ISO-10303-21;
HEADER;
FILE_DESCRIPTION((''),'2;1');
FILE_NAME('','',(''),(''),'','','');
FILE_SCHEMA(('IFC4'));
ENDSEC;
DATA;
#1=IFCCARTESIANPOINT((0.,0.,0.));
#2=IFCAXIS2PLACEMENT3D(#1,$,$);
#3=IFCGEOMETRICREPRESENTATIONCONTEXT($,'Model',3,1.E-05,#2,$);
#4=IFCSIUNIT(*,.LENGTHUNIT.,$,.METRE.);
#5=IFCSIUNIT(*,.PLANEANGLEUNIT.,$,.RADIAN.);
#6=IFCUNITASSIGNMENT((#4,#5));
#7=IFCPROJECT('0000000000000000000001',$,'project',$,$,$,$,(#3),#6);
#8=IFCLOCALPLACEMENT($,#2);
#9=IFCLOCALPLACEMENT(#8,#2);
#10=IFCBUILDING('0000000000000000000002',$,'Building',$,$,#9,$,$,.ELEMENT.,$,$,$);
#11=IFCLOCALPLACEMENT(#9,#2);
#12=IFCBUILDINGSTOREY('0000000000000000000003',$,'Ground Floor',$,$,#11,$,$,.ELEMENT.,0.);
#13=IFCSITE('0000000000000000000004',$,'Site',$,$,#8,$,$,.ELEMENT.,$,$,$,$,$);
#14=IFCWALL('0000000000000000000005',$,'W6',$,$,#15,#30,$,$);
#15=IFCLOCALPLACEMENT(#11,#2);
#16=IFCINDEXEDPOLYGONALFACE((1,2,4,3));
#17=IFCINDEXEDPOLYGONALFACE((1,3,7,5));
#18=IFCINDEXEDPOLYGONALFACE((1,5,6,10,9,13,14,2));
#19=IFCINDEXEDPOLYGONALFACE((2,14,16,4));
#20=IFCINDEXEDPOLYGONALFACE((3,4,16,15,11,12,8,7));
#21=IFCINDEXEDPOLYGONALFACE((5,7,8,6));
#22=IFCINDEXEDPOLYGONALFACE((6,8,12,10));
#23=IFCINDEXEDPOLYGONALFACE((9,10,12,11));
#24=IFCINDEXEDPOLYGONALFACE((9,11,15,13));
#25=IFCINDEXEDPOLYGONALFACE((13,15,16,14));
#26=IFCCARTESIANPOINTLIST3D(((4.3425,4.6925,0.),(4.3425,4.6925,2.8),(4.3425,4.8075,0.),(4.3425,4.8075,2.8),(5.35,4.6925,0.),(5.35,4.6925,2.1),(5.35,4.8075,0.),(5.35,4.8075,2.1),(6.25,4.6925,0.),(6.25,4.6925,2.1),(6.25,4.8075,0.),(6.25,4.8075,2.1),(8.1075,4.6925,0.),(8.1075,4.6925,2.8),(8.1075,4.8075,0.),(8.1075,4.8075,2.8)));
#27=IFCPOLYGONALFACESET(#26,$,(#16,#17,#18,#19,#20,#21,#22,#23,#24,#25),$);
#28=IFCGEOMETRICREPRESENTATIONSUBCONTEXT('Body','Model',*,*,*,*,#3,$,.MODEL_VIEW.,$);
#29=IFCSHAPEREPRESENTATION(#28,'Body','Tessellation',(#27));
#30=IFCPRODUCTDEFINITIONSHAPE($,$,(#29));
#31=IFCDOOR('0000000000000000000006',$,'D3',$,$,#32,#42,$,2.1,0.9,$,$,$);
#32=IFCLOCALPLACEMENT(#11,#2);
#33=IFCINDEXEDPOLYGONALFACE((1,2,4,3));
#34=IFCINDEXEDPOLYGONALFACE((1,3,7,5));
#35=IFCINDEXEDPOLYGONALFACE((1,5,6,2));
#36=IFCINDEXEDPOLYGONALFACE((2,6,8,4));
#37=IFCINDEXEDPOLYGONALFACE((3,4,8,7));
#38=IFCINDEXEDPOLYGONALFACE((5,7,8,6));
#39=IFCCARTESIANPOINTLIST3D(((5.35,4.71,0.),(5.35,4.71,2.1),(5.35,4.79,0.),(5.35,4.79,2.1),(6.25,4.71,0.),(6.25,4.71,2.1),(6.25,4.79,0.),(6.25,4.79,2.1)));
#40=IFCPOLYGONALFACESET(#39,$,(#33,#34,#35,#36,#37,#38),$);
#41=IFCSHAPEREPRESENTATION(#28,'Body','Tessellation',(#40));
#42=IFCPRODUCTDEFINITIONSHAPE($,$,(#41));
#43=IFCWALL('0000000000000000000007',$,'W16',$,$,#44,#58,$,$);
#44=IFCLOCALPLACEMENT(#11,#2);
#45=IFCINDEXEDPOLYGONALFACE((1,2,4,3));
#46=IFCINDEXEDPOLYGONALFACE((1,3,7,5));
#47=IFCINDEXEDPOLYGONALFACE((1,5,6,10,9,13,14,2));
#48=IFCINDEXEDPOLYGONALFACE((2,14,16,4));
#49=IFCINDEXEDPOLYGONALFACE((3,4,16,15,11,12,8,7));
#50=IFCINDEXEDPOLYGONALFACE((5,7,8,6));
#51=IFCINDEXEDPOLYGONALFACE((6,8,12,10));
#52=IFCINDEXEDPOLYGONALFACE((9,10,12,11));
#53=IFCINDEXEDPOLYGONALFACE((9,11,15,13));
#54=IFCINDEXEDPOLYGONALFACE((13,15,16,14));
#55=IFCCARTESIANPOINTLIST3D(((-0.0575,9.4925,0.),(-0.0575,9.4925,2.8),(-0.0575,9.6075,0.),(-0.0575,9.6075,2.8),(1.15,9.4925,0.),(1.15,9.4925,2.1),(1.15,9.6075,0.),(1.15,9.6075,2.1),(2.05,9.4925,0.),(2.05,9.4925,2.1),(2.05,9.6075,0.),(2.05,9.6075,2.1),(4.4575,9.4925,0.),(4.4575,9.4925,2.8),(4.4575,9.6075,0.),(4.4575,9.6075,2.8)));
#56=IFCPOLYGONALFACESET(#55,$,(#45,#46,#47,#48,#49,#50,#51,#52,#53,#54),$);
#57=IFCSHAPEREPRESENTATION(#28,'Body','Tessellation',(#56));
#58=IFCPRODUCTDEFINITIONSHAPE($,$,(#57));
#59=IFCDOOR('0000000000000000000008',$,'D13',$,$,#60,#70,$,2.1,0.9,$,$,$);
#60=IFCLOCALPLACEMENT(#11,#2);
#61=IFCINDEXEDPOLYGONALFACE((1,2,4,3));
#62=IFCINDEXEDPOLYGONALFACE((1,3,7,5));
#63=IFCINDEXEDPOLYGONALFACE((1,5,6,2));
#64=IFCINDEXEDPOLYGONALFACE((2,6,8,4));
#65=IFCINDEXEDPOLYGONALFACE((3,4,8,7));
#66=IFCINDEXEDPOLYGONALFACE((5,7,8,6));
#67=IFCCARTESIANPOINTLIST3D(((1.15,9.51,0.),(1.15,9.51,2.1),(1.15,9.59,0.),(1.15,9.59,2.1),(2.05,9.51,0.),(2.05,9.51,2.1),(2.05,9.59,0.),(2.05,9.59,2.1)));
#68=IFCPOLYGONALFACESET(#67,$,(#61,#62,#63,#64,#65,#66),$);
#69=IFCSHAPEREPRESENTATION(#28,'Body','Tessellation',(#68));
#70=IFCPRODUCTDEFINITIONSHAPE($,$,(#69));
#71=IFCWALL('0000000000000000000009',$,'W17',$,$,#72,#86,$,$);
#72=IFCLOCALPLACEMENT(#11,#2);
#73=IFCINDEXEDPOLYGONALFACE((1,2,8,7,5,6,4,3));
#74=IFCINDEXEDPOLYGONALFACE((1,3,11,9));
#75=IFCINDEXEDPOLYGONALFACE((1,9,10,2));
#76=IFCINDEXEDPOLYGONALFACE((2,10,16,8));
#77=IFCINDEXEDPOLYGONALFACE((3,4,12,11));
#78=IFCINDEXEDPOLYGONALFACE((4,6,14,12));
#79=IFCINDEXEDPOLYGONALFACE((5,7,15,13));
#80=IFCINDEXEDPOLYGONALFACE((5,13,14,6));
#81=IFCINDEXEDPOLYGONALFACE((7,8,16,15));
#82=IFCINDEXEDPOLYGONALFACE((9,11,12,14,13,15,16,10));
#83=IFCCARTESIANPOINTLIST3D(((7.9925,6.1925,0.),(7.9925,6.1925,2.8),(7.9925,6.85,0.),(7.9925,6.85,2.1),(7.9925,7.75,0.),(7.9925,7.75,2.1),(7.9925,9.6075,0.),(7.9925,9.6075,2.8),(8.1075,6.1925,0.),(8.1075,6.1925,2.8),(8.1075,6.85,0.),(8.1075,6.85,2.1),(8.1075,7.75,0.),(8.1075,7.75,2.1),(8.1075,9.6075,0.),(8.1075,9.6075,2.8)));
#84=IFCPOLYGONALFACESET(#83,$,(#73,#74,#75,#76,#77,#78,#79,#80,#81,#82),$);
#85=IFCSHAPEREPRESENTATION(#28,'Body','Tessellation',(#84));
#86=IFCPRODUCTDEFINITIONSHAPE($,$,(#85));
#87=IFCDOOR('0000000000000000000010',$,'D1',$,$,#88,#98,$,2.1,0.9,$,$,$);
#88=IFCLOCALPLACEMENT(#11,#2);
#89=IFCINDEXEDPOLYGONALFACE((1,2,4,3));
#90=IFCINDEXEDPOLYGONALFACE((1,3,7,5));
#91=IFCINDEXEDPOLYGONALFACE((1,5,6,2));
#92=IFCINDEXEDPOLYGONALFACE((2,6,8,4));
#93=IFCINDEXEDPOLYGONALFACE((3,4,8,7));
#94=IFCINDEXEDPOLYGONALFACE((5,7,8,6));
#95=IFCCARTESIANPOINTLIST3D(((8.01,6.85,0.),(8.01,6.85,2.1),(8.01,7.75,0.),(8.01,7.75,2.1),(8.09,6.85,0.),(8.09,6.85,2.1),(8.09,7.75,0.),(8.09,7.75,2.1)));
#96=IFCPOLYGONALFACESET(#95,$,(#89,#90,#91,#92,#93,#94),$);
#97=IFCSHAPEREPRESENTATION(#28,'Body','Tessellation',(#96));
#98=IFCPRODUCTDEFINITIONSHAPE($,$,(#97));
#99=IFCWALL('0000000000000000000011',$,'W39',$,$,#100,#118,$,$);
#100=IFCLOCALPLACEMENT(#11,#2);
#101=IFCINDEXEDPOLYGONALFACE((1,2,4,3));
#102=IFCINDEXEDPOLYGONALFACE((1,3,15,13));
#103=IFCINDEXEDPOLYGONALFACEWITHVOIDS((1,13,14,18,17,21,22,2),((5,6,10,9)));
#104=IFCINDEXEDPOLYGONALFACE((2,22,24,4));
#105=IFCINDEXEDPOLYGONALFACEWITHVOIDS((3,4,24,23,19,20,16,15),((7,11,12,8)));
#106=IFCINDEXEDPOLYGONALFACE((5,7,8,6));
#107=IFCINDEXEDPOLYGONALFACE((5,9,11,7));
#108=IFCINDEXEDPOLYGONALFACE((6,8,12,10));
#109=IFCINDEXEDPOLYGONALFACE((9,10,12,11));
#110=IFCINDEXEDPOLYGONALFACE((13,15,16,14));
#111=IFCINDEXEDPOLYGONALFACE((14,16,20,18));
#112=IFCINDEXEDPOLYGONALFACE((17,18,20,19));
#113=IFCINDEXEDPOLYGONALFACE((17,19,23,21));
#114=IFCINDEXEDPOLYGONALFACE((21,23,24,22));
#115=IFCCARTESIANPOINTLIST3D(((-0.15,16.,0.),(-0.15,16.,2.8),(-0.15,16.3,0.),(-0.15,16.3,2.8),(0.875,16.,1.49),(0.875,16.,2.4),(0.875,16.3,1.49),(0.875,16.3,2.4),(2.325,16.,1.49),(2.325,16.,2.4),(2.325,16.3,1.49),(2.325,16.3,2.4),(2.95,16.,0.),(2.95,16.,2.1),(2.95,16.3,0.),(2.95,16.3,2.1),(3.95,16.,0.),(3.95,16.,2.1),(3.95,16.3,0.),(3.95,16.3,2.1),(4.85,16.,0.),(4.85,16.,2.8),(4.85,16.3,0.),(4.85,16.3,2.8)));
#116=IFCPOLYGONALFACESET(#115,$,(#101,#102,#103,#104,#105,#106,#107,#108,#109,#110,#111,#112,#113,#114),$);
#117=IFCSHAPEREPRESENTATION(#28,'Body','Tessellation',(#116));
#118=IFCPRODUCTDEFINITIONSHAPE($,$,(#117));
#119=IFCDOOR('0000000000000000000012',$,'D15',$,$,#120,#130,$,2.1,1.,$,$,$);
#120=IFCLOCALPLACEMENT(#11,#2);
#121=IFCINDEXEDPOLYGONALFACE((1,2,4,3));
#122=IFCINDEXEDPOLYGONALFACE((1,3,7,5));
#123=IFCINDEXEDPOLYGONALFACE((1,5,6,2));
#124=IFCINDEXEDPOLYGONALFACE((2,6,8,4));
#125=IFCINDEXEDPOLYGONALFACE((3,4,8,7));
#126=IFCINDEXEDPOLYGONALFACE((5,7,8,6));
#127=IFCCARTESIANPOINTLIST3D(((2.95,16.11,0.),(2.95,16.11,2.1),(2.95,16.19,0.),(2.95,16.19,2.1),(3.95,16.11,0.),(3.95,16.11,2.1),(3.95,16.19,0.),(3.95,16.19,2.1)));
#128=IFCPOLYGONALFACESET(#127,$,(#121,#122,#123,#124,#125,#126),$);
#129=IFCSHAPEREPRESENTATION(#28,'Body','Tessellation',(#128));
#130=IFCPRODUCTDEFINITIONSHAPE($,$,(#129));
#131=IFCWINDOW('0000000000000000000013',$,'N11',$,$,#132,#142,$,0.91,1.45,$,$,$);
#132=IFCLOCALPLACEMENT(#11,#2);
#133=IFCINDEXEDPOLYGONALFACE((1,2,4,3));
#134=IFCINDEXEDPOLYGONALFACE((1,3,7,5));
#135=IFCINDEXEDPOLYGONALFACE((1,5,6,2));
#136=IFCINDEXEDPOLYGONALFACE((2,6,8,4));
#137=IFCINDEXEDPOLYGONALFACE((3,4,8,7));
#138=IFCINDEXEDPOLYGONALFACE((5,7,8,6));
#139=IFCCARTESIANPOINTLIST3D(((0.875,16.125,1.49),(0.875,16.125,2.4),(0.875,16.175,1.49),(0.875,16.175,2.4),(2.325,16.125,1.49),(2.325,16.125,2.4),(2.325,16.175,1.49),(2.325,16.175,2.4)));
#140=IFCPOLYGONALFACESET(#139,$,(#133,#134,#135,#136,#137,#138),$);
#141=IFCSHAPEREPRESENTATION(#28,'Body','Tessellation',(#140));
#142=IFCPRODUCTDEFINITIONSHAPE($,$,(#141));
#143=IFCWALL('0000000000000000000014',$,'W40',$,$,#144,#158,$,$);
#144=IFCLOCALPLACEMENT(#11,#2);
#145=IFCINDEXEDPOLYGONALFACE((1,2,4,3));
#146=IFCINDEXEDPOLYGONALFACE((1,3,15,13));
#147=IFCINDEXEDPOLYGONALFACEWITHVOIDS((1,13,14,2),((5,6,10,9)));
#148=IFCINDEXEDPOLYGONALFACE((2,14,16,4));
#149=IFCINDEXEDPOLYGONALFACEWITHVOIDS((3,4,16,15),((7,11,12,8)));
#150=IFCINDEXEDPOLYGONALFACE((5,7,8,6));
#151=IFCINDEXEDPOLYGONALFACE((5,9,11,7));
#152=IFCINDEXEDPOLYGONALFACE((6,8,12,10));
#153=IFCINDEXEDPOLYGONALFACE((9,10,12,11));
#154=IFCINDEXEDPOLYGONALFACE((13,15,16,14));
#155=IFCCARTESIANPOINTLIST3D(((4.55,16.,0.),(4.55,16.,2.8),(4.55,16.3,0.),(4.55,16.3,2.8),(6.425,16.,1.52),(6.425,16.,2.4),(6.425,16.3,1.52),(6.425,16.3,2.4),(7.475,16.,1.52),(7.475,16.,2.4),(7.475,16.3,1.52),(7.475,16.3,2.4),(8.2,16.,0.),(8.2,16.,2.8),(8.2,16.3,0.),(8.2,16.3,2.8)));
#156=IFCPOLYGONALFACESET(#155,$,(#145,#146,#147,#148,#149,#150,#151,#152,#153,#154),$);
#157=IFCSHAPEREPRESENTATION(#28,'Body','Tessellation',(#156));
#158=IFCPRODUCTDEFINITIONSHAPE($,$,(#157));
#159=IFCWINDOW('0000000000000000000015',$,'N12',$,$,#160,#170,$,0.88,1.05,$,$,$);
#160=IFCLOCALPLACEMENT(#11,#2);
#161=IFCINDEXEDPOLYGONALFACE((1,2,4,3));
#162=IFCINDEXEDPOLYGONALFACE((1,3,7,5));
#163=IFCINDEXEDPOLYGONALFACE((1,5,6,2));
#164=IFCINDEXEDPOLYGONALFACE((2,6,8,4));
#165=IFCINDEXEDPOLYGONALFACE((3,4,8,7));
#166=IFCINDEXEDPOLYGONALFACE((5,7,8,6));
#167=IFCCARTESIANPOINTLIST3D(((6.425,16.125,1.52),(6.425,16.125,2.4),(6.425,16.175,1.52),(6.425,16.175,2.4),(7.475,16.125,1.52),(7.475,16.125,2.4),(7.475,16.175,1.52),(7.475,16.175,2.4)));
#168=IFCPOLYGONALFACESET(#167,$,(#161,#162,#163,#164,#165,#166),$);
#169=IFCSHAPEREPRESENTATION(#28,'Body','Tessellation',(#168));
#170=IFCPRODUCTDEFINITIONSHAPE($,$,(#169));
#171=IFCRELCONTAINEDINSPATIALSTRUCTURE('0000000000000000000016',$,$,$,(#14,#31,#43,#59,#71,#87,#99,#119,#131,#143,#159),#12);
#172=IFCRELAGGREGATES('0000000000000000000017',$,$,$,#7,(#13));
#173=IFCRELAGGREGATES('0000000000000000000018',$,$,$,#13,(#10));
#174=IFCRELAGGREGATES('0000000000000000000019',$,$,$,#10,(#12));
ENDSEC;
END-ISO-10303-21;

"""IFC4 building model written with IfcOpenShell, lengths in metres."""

from ifc_helpers import new_model, si_unit, frame, frame_2d, origin, origin_2d, place, context, subcontext, project, spatial, rectangle, extrude, element, fill, save


model = new_model("IFC4")

# Units and contexts
model_context = context("Model", 3, precision=1e-05, world=origin())
body_context = subcontext(model_context, "Body", "Model", "MODEL_VIEW")
ifc_project = project(units=[si_unit("LENGTHUNIT", "METRE"), si_unit("PLANEANGLEUNIT", "RADIAN")], contexts=[model_context])

# Site, building, storey
site_placement = place(None, origin())
site = spatial("IfcSite", under=ifc_project, at=site_placement, Name="Site", CompositionType="ELEMENT")
building_placement = place(site_placement, origin())
building = spatial("IfcBuilding", under=site, at=building_placement, Name="Building", CompositionType="ELEMENT")
storey_placement = place(building_placement, origin())
storey = spatial("IfcBuildingStorey", under=building, at=storey_placement, Name="Ground Floor", CompositionType="ELEMENT", Elevation=0.0)

# Wall, opening, door
wall_1_placement = place(storey_placement, frame((4.4, 4.75, 0.0), x_axis=(1.0, 0.0, 0.0)))
wall_1 = element("IfcWall", 1, at=wall_1_placement, inside=storey, Name="W6", context=body_context, shape_type="SweptSolid", body=[
    extrude(rectangle(XDim=3.765, YDim=0.115, at=frame_2d((1.825, 0.0))), origin(), (0.0, 0.0, 1.0), 2.8),
])
opening_1_placement = place(wall_1_placement, frame((1.4, 0.0, 0.0)))
opening_1 = element("IfcOpeningElement", 2, at=opening_1_placement, cuts=wall_1, context=body_context, shape_type="SweptSolid", body=[
    extrude(rectangle(XDim=0.9, YDim=0.215, at=origin_2d()), origin(), (0.0, 0.0, 1.0), 2.1),
])
door_1_placement = place(opening_1_placement, origin())
door_1 = element("IfcDoor", 3, at=door_1_placement, inside=storey, Name="D3", OverallHeight=2.1, OverallWidth=0.9, context=body_context, shape_type="SweptSolid", body=[
    extrude(rectangle(XDim=0.9, YDim=0.08, at=origin_2d()), origin(), (0.0, 0.0, 1.0), 2.1),
])
fill(opening_1, door_1)

# Walls, openings, doors
wall_2_placement = place(storey_placement, frame((0.0, 9.55, 0.0), x_axis=(1.0, 0.0, 0.0)))
wall_2 = element("IfcWall", 4, at=wall_2_placement, inside=storey, Name="W16", context=body_context, shape_type="SweptSolid", body=[
    extrude(rectangle(XDim=4.515, YDim=0.115, at=frame_2d((2.2, 0.0))), origin(), (0.0, 0.0, 1.0), 2.8),
])
opening_2_placement = place(wall_2_placement, frame((1.6, 0.0, 0.0)))
opening_2 = element("IfcOpeningElement", 5, at=opening_2_placement, cuts=wall_2, context=body_context, shape_type="SweptSolid", body=[
    extrude(rectangle(XDim=0.9, YDim=0.215, at=origin_2d()), origin(), (0.0, 0.0, 1.0), 2.1),
])
door_2_placement = place(opening_2_placement, origin())
door_2 = element("IfcDoor", 6, at=door_2_placement, inside=storey, Name="D13", OverallHeight=2.1, OverallWidth=0.9, context=body_context, shape_type="SweptSolid", body=[
    extrude(rectangle(XDim=0.9, YDim=0.08, at=origin_2d()), origin(), (0.0, 0.0, 1.0), 2.1),
])
fill(opening_2, door_2)
wall_3_placement = place(storey_placement, frame((8.05, 6.25, 0.0), x_axis=(0.0, 1.0, 0.0)))
wall_3 = element("IfcWall", 7, at=wall_3_placement, inside=storey, Name="W17", context=body_context, shape_type="SweptSolid", body=[
    extrude(rectangle(XDim=3.415, YDim=0.115, at=frame_2d((1.65, 0.0))), origin(), (0.0, 0.0, 1.0), 2.8),
])
opening_3_placement = place(wall_3_placement, frame((1.05, 0.0, 0.0)))
opening_3 = element("IfcOpeningElement", 8, at=opening_3_placement, cuts=wall_3, context=body_context, shape_type="SweptSolid", body=[
    extrude(rectangle(XDim=0.9, YDim=0.215, at=origin_2d()), origin(), (0.0, 0.0, 1.0), 2.1),
])
door_3_placement = place(opening_3_placement, origin())
door_3 = element("IfcDoor", 9, at=door_3_placement, inside=storey, Name="D1", OverallHeight=2.1, OverallWidth=0.9, context=body_context, shape_type="SweptSolid", body=[
    extrude(rectangle(XDim=0.9, YDim=0.08, at=origin_2d()), origin(), (0.0, 0.0, 1.0), 2.1),
])
fill(opening_3, door_3)

# Wall, openings, door, window
wall_4_placement = place(storey_placement, frame((0.0, 16.15, 0.0), x_axis=(1.0, 0.0, 0.0)))
wall_4 = element("IfcWall", 10, at=wall_4_placement, inside=storey, Name="W39", context=body_context, shape_type="SweptSolid", body=[
    extrude(rectangle(XDim=5.0, YDim=0.3, at=frame_2d((2.35, 0.0))), origin(), (0.0, 0.0, 1.0), 2.8),
])
opening_4_placement = place(wall_4_placement, frame((3.45, 0.0, 0.0)))
opening_4 = element("IfcOpeningElement", 11, at=opening_4_placement, cuts=wall_4, context=body_context, shape_type="SweptSolid", body=[
    extrude(rectangle(XDim=1.0, YDim=0.4, at=origin_2d()), origin(), (0.0, 0.0, 1.0), 2.1),
])
opening_5_placement = place(wall_4_placement, frame((1.6, 0.0, 1.49)))
opening_5 = element("IfcOpeningElement", 12, at=opening_5_placement, cuts=wall_4, context=body_context, shape_type="SweptSolid", body=[
    extrude(rectangle(XDim=1.45, YDim=0.4, at=origin_2d()), origin(), (0.0, 0.0, 1.0), 0.91),
])
door_4_placement = place(opening_4_placement, origin())
door_4 = element("IfcDoor", 13, at=door_4_placement, inside=storey, Name="D15", OverallHeight=2.1, OverallWidth=1.0, context=body_context, shape_type="SweptSolid", body=[
    extrude(rectangle(XDim=1.0, YDim=0.08, at=origin_2d()), origin(), (0.0, 0.0, 1.0), 2.1),
])
fill(opening_4, door_4)
window_1_placement = place(opening_5_placement, origin())
window_1 = element("IfcWindow", 14, at=window_1_placement, inside=storey, Name="N11", OverallHeight=0.91, OverallWidth=1.45, context=body_context, shape_type="SweptSolid", body=[
    extrude(rectangle(XDim=1.45, YDim=0.05, at=origin_2d()), origin(), (0.0, 0.0, 1.0), 0.91),
])
fill(opening_5, window_1)

# Wall, opening, window
wall_5_placement = place(storey_placement, frame((4.7, 16.15, 0.0), x_axis=(1.0, 0.0, 0.0)))
wall_5 = element("IfcWall", 15, at=wall_5_placement, inside=storey, Name="W40", context=body_context, shape_type="SweptSolid", body=[
    extrude(rectangle(XDim=3.65, YDim=0.3, at=frame_2d((1.675, 0.0))), origin(), (0.0, 0.0, 1.0), 2.8),
])
opening_6_placement = place(wall_5_placement, frame((2.25, 0.0, 1.52)))
opening_6 = element("IfcOpeningElement", 16, at=opening_6_placement, cuts=wall_5, context=body_context, shape_type="SweptSolid", body=[
    extrude(rectangle(XDim=1.05, YDim=0.4, at=origin_2d()), origin(), (0.0, 0.0, 1.0), 0.88),
])
window_2_placement = place(opening_6_placement, origin())
window_2 = element("IfcWindow", 17, at=window_2_placement, inside=storey, Name="N12", OverallHeight=0.88, OverallWidth=1.05, context=body_context, shape_type="SweptSolid", body=[
    extrude(rectangle(XDim=1.05, YDim=0.05, at=origin_2d()), origin(), (0.0, 0.0, 1.0), 0.88),
])
fill(opening_6, window_2)

save(model, "model.ifc")
